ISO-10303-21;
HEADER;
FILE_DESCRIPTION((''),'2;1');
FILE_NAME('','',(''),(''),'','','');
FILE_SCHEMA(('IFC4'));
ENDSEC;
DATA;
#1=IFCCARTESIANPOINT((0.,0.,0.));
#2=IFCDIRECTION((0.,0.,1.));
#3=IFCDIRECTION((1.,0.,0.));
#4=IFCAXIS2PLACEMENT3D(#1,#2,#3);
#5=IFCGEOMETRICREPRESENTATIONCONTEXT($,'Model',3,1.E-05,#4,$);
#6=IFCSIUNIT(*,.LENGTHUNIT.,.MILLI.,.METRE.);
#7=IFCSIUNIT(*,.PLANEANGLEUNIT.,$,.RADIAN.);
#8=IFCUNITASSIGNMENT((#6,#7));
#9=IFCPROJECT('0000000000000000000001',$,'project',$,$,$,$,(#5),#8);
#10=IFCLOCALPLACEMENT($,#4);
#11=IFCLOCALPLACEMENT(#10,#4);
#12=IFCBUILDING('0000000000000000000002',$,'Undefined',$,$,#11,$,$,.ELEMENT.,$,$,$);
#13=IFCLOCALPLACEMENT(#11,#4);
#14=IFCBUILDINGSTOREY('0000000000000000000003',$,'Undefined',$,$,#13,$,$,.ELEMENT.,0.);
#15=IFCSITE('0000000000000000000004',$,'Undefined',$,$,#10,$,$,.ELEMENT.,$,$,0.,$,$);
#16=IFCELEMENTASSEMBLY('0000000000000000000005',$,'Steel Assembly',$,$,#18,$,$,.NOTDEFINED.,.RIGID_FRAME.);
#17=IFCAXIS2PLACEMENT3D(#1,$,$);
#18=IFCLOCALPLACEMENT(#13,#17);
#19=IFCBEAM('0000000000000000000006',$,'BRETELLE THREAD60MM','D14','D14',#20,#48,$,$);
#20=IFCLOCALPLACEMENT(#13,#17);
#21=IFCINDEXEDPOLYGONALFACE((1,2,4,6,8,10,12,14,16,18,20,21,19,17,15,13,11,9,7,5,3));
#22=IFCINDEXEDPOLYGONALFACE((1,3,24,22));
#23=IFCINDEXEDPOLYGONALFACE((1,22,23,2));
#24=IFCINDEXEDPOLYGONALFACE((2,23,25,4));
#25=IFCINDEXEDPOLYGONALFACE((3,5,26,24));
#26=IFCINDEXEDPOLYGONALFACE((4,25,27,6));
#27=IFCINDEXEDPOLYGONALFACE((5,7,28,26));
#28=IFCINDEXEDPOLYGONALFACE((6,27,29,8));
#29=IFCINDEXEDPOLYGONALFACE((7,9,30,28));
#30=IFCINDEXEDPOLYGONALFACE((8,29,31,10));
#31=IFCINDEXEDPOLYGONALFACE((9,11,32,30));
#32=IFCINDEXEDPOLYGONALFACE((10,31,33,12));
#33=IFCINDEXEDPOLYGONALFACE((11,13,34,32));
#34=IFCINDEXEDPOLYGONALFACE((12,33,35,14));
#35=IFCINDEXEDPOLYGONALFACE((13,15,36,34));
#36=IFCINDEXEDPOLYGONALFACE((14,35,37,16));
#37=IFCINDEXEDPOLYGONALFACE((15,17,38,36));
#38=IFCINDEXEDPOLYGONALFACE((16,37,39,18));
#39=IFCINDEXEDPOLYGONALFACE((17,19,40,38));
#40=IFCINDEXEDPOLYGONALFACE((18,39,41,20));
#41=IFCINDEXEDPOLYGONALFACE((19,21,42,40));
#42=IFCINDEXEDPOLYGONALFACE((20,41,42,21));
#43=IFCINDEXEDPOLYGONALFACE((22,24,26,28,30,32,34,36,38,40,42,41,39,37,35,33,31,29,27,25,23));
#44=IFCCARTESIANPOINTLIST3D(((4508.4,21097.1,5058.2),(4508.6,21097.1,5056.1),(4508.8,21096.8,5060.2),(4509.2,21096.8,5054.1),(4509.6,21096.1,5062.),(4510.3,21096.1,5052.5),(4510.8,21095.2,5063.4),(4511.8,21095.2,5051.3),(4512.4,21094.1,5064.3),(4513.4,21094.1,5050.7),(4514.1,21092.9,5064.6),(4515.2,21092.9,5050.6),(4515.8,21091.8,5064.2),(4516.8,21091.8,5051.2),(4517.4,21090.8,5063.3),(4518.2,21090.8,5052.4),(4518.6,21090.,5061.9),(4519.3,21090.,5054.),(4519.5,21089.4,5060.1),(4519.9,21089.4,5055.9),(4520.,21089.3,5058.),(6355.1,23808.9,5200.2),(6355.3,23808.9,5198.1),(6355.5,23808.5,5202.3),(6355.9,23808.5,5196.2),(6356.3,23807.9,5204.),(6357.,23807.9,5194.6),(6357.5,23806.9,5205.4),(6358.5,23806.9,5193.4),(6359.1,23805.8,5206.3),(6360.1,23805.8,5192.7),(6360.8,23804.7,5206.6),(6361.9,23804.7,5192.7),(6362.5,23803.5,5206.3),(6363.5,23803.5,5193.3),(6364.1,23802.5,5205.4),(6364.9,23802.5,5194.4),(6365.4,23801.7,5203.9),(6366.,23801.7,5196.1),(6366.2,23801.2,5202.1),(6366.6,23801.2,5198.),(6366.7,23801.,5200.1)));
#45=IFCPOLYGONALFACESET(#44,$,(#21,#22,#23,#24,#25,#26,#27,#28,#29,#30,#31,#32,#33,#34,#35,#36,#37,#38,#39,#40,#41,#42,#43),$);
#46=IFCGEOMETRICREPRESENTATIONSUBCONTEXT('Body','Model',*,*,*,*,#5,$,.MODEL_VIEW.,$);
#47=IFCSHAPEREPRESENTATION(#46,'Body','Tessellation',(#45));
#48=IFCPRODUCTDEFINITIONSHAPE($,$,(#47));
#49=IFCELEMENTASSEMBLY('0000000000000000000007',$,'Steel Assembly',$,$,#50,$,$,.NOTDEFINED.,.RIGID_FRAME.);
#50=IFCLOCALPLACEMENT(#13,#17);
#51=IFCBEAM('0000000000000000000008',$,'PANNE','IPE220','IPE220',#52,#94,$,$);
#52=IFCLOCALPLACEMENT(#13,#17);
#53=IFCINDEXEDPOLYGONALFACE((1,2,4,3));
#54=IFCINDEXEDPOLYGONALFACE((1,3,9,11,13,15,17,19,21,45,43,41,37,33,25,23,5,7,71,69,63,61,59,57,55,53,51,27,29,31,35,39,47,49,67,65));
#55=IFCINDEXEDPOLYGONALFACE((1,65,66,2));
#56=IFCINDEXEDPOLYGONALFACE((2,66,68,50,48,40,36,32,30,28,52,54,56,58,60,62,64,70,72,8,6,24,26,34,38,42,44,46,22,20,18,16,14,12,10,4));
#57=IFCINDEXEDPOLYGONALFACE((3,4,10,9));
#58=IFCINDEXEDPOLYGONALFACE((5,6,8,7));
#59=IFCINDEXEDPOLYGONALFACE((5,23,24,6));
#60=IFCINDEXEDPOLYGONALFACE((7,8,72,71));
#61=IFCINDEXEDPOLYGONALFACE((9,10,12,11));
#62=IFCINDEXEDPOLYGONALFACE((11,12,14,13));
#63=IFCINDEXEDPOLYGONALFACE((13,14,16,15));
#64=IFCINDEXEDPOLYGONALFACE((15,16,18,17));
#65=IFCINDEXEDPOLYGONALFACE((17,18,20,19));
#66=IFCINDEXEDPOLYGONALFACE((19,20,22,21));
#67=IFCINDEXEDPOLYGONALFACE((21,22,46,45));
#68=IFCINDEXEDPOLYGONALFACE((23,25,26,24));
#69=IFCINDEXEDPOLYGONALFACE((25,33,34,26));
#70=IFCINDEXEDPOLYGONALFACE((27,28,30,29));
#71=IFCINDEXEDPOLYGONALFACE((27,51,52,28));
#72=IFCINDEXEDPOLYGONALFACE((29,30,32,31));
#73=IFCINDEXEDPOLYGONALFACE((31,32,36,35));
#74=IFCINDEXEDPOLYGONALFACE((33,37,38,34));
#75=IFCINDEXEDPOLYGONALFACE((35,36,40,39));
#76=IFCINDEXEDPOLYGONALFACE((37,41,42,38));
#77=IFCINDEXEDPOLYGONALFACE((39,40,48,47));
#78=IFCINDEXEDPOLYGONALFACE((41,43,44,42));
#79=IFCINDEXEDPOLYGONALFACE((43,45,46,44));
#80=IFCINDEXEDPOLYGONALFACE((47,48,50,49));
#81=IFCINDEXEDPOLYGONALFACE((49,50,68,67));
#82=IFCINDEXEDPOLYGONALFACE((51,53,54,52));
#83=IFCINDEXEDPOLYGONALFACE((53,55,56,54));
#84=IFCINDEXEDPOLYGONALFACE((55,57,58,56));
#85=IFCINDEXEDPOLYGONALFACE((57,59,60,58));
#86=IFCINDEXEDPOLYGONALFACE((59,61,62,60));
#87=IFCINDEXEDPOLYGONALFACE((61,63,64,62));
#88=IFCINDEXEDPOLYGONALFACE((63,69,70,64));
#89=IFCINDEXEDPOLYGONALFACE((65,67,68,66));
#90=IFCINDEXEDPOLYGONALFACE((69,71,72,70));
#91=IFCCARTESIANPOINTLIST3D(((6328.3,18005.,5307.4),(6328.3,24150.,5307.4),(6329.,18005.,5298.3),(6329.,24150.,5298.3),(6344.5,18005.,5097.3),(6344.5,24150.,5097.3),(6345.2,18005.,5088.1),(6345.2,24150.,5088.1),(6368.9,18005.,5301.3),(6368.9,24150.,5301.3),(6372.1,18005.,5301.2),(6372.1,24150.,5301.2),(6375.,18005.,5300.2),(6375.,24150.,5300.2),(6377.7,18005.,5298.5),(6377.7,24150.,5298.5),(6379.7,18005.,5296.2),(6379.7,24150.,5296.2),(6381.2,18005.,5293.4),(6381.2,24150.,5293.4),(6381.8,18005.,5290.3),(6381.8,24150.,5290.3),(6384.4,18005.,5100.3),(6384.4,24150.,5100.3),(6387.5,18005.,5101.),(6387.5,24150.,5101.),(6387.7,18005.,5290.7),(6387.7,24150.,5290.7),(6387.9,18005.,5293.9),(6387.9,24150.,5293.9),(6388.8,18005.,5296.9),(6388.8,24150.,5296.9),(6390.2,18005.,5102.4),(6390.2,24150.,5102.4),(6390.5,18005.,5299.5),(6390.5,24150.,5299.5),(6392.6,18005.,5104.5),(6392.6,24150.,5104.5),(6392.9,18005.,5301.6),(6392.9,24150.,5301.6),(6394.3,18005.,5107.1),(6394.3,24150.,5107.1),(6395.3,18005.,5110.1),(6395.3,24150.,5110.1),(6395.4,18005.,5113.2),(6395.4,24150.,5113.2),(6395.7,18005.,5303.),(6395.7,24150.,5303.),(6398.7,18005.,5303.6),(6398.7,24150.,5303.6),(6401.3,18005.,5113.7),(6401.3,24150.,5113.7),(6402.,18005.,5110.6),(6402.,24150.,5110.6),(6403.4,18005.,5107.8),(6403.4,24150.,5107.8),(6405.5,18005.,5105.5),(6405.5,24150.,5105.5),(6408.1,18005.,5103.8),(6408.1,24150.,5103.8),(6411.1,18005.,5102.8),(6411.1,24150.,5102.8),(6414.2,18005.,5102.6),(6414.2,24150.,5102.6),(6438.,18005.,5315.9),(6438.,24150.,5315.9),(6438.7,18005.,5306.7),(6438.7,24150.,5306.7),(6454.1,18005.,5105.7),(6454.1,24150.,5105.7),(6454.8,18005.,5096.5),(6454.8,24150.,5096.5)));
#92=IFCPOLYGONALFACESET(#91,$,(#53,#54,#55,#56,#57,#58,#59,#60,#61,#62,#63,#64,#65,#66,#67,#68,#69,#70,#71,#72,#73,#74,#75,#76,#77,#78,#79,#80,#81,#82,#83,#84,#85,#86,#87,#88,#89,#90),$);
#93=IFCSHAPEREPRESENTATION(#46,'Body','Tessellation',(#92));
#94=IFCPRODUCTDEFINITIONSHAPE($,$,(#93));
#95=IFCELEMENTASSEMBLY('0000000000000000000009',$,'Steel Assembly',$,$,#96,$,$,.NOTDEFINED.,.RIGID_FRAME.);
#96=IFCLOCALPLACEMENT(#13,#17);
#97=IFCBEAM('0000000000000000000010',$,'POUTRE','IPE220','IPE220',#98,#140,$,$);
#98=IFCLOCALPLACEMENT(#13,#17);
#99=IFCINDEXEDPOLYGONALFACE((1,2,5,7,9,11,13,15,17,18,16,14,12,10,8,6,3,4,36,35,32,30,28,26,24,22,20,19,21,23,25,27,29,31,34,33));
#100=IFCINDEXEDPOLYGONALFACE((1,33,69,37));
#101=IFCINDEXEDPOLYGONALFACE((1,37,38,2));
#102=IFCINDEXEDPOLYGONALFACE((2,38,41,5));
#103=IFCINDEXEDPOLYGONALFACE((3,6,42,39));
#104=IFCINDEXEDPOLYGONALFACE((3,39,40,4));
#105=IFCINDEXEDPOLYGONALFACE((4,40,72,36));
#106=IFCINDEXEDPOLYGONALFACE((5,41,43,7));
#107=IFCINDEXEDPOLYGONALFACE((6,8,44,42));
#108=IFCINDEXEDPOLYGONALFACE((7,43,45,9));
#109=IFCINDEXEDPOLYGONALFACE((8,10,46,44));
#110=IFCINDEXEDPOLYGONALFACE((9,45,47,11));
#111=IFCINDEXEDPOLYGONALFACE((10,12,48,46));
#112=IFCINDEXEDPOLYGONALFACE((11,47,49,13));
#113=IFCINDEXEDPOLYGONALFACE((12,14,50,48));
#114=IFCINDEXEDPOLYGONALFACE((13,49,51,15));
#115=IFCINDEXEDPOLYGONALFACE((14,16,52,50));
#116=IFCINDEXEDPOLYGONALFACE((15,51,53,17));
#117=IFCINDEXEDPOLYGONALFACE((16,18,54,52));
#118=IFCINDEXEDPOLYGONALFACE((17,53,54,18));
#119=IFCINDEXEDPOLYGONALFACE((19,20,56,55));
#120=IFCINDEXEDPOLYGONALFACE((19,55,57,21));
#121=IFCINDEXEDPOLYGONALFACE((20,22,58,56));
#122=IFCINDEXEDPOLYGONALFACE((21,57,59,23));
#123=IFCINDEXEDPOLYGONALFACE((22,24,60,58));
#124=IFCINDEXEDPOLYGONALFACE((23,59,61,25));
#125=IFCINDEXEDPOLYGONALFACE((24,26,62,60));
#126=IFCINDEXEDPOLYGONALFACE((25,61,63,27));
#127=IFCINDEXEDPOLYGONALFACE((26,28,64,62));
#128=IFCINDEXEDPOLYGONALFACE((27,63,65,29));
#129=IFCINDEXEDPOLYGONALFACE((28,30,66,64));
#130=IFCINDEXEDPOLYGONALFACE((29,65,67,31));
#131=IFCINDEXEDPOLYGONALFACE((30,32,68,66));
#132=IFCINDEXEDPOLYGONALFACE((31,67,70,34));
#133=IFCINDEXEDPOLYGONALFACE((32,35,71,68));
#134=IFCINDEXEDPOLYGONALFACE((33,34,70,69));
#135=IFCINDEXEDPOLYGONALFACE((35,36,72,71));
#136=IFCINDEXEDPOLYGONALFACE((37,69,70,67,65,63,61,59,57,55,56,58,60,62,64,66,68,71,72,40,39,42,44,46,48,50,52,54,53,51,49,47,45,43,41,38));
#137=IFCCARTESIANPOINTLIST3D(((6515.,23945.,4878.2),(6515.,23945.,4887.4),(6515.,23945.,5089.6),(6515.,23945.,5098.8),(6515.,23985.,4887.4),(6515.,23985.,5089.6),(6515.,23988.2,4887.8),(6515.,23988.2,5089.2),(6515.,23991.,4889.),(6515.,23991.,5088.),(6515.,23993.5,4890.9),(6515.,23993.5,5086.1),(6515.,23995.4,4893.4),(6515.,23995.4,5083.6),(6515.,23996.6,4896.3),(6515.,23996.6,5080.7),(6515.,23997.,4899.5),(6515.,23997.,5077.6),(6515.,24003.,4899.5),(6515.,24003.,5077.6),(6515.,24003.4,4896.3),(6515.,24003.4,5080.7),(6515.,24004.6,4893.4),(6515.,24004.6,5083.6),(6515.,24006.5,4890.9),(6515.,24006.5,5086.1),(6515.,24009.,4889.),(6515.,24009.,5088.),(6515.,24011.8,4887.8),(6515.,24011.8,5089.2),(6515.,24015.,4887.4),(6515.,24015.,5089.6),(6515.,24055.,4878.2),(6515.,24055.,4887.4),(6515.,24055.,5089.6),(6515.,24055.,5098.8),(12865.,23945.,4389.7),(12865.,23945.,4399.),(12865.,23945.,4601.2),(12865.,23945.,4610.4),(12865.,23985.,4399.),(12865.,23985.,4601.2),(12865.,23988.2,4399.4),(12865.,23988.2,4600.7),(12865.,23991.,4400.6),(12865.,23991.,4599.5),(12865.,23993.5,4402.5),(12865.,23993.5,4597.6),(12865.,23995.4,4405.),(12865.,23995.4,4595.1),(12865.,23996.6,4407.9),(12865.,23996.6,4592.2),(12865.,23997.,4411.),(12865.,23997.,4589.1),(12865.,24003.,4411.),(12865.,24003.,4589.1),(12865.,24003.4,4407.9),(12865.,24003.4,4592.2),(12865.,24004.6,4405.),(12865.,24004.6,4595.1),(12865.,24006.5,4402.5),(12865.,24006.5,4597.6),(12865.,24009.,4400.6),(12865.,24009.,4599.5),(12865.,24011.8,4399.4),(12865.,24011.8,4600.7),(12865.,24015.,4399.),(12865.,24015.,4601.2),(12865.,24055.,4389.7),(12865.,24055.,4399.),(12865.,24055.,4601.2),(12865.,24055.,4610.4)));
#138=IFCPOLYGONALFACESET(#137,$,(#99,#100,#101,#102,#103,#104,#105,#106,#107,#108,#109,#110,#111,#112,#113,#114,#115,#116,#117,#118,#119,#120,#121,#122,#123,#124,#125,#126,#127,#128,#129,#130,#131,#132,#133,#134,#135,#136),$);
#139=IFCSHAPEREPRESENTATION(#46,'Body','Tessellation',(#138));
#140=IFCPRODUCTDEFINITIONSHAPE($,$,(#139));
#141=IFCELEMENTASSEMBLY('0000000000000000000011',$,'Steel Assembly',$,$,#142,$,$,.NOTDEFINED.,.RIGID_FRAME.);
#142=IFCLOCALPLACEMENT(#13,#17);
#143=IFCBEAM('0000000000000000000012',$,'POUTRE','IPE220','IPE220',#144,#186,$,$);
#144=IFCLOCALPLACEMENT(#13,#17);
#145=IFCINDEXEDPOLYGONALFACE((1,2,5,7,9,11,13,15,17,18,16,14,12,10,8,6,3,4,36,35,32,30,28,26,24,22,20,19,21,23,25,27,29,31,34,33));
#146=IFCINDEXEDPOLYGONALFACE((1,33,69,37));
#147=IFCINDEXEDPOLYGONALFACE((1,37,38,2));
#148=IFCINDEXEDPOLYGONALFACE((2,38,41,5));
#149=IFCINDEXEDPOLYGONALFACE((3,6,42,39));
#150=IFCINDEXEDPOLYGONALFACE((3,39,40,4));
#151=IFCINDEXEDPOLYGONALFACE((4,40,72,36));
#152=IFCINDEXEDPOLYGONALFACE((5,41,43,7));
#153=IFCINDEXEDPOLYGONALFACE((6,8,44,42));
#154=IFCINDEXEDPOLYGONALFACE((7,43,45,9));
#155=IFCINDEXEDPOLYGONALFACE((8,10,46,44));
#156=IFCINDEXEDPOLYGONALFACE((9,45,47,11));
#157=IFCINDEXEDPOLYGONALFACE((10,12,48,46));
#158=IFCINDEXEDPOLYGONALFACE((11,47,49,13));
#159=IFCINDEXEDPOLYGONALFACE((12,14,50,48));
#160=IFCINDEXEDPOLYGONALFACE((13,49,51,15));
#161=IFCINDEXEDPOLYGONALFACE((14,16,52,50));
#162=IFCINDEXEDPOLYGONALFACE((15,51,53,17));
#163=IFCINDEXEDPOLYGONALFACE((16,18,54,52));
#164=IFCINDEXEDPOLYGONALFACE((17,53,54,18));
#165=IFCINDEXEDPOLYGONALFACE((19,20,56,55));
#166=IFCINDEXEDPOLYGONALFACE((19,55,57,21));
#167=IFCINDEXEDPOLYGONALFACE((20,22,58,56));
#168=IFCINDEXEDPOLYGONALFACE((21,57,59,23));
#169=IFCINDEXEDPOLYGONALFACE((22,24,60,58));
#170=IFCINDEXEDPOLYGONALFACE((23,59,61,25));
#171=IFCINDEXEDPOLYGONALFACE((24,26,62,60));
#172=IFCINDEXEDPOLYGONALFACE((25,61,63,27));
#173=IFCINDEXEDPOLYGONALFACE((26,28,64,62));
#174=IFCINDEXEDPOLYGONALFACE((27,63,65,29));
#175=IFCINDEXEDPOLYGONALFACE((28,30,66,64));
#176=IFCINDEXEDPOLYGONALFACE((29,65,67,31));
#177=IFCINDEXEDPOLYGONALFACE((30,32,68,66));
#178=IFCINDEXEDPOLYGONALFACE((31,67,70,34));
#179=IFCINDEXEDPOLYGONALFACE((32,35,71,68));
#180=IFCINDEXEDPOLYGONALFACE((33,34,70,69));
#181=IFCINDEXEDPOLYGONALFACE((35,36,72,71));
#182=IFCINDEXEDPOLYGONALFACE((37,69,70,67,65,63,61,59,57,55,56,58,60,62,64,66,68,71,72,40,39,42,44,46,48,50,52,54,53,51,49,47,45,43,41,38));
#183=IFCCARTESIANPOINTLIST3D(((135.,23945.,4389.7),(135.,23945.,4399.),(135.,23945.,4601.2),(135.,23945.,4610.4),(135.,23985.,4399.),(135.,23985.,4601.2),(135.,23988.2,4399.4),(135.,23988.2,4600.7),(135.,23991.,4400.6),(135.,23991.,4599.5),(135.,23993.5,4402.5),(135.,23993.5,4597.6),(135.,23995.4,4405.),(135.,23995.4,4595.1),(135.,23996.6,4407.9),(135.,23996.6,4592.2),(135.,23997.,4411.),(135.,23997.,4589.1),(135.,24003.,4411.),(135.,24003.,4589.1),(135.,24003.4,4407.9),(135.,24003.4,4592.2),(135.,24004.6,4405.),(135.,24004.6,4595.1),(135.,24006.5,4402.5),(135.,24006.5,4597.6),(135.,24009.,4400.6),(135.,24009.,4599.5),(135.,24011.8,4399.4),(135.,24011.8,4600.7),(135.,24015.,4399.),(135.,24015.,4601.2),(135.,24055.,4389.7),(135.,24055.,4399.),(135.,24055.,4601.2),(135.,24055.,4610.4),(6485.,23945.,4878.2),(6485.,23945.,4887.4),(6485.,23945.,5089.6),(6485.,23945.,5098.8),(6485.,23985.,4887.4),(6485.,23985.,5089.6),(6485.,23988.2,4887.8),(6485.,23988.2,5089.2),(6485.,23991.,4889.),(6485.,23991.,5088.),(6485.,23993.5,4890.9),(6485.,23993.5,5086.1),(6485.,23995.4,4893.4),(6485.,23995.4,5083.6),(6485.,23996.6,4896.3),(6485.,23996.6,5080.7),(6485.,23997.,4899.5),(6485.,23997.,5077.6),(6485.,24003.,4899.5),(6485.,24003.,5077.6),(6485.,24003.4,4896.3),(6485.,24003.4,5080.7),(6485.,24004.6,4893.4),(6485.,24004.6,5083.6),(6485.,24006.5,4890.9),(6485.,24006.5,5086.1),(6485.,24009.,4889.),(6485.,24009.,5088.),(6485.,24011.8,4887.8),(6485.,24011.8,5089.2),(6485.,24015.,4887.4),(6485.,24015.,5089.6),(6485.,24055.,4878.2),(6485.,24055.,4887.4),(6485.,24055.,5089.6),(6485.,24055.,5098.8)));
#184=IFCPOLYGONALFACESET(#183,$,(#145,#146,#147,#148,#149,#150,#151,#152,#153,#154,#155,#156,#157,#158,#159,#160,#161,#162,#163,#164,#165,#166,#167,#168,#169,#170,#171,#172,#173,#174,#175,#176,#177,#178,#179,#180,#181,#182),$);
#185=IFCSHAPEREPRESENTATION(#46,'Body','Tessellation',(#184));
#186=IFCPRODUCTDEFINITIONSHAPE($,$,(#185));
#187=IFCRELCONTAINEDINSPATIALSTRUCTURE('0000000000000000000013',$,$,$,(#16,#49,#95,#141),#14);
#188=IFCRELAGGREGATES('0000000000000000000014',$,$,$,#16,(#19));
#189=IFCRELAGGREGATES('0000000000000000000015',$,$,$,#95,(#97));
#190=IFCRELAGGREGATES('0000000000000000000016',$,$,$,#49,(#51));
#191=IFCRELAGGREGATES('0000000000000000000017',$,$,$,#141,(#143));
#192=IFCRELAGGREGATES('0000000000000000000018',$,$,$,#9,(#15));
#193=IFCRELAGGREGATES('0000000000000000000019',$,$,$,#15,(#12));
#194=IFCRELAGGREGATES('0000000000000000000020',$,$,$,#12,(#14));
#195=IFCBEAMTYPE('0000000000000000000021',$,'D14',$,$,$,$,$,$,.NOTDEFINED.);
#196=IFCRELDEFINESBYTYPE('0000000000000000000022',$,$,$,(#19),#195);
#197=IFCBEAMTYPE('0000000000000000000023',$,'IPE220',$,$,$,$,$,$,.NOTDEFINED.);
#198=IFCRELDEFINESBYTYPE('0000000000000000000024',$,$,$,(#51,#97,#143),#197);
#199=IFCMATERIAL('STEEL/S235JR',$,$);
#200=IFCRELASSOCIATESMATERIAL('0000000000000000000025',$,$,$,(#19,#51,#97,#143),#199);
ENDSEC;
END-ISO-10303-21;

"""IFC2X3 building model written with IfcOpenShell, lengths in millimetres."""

from ifc_helpers import new_model, si_unit, frame, origin_with_axes, origin_2d_with_axis, place, context, subcontext, project, spatial, circle, i_section, extrude, clip, halfspace, material, type_object, element, aggregate, save


model = new_model("IFC2X3")

# Units and contexts
model_context = context("Model", 3, precision=1e-05, world=origin_with_axes())
body_context = subcontext(model_context, "Body", "Model", "MODEL_VIEW")
ifc_project = project(units=[si_unit("LENGTHUNIT", "METRE", prefix="MILLI"), si_unit("PLANEANGLEUNIT", "RADIAN")], contexts=[model_context])

# Site, building, storey
site_placement = place(None, origin_with_axes())
site = spatial("IfcSite", under=ifc_project, at=site_placement, Name="Undefined", CompositionType="ELEMENT", RefElevation=0.0)
building_placement = place(site_placement, origin_with_axes())
building = spatial("IfcBuilding", under=site, at=building_placement, Name="Undefined", CompositionType="ELEMENT")
storey_placement = place(building_placement, origin_with_axes())
storey = spatial("IfcBuildingStorey", under=building, at=storey_placement, Name="Undefined", CompositionType="ELEMENT", Elevation=0.0)

# Element assemblies, beams
assembly_1_placement = place(storey_placement, origin_with_axes())
assembly_1 = element("IfcElementAssembly", 1, at=assembly_1_placement, inside=storey, Name="Steel Assembly", AssemblyPlace="NOTDEFINED", PredefinedType="RIGID_FRAME")
ifc_material_1 = material(Name="STEEL/S235JR")
beam_type_1 = type_object("IfcBeamType", Name="D14", PredefinedType="NOTDEFINED")
beam_1_placement = place(assembly_1_placement, frame((6360.9, 23805.0, 5199.6), z_axis=(0.076696, 0.0, -0.997054), x_axis=(-0.56235, -0.825767, -0.043258)))
beam_1 = element("IfcBeam", 2, at=beam_1_placement, type_object=beam_type_1, material=ifc_material_1, Name="BRETELLE THREAD60MM", Description="D14", ObjectType="D14", context=body_context, shape_type="SweptSolid", body=[
    extrude(circle(Radius=7.0, at=origin_2d_with_axis()), frame((3283.9, 0.0, 0.0), z_axis=(-1.0, 0.0, 0.0), x_axis=(0.0, -1.0, 0.0)), (0.0, 0.0, 1.0), 3283.9),
])
aggregate(assembly_1, [beam_1])
assembly_2_placement = place(storey_placement, origin_with_axes())
assembly_2 = element("IfcElementAssembly", 3, at=assembly_2_placement, inside=storey, Name="Steel Assembly", AssemblyPlace="NOTDEFINED", PredefinedType="RIGID_FRAME")
beam_type_2 = type_object("IfcBeamType", Name="IPE220", PredefinedType="NOTDEFINED")
beam_2_placement = place(assembly_2_placement, frame((6391.6, 24150.0, 5202.0), z_axis=(-0.076696, 0.0, 0.997054), x_axis=(0.0, -1.0, 0.0)))
beam_2 = element("IfcBeam", 4, at=beam_2_placement, type_object=beam_type_2, material=ifc_material_1, Name="PANNE", Description="IPE220", ObjectType="IPE220", context=body_context, shape_type="Clipping", body=[
    clip(extrude(i_section(OverallWidth=110.0, OverallDepth=220.0, WebThickness=5.9, FlangeThickness=9.2, FilletRadius=12.0, at=origin_2d_with_axis()), frame((6145.0, 0.0, 0.0), z_axis=(-1.0, 0.0, 0.0), x_axis=(0.0, -1.0, 0.0)), (0.0, 0.0, 1.0), 6145.0), halfspace(frame((6145.0, 0.0, 0.0), z_axis=(1.0, 0.0, 0.0), x_axis=(0.0, -1.0, 0.0)), False)),
])
assembly_3_placement = place(storey_placement, origin_with_axes())
assembly_3 = element("IfcElementAssembly", 5, at=assembly_3_placement, inside=storey, Name="Steel Assembly", AssemblyPlace="NOTDEFINED", PredefinedType="RIGID_FRAME")
beam_3_placement = place(assembly_3_placement, frame((6491.6, 24000.0, 4990.3), z_axis=(0.076696, 0.0, 0.997054), x_axis=(0.997054, 0.0, -0.076696)))
beam_3 = element("IfcBeam", 6, at=beam_3_placement, type_object=beam_type_2, material=ifc_material_1, Name="POUTRE", Description="IPE220", ObjectType="IPE220", context=body_context, shape_type="Clipping", body=[
    clip(clip(extrude(i_section(OverallWidth=110.0, OverallDepth=220.0, WebThickness=5.9, FlangeThickness=9.2, FilletRadius=12.0, at=origin_2d_with_axis()), frame((6409.4, 0.0, 0.0), z_axis=(-1.0, 0.0, 0.0), x_axis=(0.0, -1.0, 0.0)), (0.0, 0.0, 1.0), 6402.9), halfspace(frame((6400.7, 0.0, -110.0), z_axis=(-0.997054, 0.0, -0.076696), x_axis=(-0.076696, 0.0, 0.997054)), True)), halfspace(frame((15.0, 0.0, 111.2), z_axis=(-0.997054, 0.0, -0.076696), x_axis=(0.0, -1.0, 0.0)), False)),
])
aggregate(assembly_3, [beam_3])
assembly_4_placement = place(storey_placement, origin_with_axes())
assembly_4 = element("IfcElementAssembly", 7, at=assembly_4_placement, inside=storey, Name="Steel Assembly", AssemblyPlace="NOTDEFINED", PredefinedType="RIGID_FRAME")
beam_4_placement = place(assembly_4_placement, frame((8.4, 24000.0, 4490.3), z_axis=(-0.076696, 0.0, 0.997054), x_axis=(0.997054, 0.0, 0.076696)))
beam_4 = element("IfcBeam", 8, at=beam_4_placement, type_object=beam_type_2, material=ifc_material_1, Name="POUTRE", Description="IPE220", ObjectType="IPE220", context=body_context, shape_type="Clipping", body=[
    clip(clip(extrude(i_section(OverallWidth=110.0, OverallDepth=220.0, WebThickness=5.9, FlangeThickness=9.2, FilletRadius=12.0, at=origin_2d_with_axis()), frame((6512.8, 0.0, 0.0), z_axis=(-1.0, 0.0, 0.0), x_axis=(0.0, -1.0, 0.0)), (0.0, 0.0, 1.0), 6402.9), halfspace(frame((6504.2, 0.0, 111.2), z_axis=(-0.997054, 0.0, 0.076696), x_axis=(0.0, -1.0, 0.0)), True)), halfspace(frame((118.5, 0.0, -110.0), z_axis=(0.997054, 0.0, -0.076696), x_axis=(0.0, -1.0, 0.0)), True)),
])

aggregate(assembly_2, [beam_2])

aggregate(assembly_4, [beam_4])

save(model, "model.ifc")
